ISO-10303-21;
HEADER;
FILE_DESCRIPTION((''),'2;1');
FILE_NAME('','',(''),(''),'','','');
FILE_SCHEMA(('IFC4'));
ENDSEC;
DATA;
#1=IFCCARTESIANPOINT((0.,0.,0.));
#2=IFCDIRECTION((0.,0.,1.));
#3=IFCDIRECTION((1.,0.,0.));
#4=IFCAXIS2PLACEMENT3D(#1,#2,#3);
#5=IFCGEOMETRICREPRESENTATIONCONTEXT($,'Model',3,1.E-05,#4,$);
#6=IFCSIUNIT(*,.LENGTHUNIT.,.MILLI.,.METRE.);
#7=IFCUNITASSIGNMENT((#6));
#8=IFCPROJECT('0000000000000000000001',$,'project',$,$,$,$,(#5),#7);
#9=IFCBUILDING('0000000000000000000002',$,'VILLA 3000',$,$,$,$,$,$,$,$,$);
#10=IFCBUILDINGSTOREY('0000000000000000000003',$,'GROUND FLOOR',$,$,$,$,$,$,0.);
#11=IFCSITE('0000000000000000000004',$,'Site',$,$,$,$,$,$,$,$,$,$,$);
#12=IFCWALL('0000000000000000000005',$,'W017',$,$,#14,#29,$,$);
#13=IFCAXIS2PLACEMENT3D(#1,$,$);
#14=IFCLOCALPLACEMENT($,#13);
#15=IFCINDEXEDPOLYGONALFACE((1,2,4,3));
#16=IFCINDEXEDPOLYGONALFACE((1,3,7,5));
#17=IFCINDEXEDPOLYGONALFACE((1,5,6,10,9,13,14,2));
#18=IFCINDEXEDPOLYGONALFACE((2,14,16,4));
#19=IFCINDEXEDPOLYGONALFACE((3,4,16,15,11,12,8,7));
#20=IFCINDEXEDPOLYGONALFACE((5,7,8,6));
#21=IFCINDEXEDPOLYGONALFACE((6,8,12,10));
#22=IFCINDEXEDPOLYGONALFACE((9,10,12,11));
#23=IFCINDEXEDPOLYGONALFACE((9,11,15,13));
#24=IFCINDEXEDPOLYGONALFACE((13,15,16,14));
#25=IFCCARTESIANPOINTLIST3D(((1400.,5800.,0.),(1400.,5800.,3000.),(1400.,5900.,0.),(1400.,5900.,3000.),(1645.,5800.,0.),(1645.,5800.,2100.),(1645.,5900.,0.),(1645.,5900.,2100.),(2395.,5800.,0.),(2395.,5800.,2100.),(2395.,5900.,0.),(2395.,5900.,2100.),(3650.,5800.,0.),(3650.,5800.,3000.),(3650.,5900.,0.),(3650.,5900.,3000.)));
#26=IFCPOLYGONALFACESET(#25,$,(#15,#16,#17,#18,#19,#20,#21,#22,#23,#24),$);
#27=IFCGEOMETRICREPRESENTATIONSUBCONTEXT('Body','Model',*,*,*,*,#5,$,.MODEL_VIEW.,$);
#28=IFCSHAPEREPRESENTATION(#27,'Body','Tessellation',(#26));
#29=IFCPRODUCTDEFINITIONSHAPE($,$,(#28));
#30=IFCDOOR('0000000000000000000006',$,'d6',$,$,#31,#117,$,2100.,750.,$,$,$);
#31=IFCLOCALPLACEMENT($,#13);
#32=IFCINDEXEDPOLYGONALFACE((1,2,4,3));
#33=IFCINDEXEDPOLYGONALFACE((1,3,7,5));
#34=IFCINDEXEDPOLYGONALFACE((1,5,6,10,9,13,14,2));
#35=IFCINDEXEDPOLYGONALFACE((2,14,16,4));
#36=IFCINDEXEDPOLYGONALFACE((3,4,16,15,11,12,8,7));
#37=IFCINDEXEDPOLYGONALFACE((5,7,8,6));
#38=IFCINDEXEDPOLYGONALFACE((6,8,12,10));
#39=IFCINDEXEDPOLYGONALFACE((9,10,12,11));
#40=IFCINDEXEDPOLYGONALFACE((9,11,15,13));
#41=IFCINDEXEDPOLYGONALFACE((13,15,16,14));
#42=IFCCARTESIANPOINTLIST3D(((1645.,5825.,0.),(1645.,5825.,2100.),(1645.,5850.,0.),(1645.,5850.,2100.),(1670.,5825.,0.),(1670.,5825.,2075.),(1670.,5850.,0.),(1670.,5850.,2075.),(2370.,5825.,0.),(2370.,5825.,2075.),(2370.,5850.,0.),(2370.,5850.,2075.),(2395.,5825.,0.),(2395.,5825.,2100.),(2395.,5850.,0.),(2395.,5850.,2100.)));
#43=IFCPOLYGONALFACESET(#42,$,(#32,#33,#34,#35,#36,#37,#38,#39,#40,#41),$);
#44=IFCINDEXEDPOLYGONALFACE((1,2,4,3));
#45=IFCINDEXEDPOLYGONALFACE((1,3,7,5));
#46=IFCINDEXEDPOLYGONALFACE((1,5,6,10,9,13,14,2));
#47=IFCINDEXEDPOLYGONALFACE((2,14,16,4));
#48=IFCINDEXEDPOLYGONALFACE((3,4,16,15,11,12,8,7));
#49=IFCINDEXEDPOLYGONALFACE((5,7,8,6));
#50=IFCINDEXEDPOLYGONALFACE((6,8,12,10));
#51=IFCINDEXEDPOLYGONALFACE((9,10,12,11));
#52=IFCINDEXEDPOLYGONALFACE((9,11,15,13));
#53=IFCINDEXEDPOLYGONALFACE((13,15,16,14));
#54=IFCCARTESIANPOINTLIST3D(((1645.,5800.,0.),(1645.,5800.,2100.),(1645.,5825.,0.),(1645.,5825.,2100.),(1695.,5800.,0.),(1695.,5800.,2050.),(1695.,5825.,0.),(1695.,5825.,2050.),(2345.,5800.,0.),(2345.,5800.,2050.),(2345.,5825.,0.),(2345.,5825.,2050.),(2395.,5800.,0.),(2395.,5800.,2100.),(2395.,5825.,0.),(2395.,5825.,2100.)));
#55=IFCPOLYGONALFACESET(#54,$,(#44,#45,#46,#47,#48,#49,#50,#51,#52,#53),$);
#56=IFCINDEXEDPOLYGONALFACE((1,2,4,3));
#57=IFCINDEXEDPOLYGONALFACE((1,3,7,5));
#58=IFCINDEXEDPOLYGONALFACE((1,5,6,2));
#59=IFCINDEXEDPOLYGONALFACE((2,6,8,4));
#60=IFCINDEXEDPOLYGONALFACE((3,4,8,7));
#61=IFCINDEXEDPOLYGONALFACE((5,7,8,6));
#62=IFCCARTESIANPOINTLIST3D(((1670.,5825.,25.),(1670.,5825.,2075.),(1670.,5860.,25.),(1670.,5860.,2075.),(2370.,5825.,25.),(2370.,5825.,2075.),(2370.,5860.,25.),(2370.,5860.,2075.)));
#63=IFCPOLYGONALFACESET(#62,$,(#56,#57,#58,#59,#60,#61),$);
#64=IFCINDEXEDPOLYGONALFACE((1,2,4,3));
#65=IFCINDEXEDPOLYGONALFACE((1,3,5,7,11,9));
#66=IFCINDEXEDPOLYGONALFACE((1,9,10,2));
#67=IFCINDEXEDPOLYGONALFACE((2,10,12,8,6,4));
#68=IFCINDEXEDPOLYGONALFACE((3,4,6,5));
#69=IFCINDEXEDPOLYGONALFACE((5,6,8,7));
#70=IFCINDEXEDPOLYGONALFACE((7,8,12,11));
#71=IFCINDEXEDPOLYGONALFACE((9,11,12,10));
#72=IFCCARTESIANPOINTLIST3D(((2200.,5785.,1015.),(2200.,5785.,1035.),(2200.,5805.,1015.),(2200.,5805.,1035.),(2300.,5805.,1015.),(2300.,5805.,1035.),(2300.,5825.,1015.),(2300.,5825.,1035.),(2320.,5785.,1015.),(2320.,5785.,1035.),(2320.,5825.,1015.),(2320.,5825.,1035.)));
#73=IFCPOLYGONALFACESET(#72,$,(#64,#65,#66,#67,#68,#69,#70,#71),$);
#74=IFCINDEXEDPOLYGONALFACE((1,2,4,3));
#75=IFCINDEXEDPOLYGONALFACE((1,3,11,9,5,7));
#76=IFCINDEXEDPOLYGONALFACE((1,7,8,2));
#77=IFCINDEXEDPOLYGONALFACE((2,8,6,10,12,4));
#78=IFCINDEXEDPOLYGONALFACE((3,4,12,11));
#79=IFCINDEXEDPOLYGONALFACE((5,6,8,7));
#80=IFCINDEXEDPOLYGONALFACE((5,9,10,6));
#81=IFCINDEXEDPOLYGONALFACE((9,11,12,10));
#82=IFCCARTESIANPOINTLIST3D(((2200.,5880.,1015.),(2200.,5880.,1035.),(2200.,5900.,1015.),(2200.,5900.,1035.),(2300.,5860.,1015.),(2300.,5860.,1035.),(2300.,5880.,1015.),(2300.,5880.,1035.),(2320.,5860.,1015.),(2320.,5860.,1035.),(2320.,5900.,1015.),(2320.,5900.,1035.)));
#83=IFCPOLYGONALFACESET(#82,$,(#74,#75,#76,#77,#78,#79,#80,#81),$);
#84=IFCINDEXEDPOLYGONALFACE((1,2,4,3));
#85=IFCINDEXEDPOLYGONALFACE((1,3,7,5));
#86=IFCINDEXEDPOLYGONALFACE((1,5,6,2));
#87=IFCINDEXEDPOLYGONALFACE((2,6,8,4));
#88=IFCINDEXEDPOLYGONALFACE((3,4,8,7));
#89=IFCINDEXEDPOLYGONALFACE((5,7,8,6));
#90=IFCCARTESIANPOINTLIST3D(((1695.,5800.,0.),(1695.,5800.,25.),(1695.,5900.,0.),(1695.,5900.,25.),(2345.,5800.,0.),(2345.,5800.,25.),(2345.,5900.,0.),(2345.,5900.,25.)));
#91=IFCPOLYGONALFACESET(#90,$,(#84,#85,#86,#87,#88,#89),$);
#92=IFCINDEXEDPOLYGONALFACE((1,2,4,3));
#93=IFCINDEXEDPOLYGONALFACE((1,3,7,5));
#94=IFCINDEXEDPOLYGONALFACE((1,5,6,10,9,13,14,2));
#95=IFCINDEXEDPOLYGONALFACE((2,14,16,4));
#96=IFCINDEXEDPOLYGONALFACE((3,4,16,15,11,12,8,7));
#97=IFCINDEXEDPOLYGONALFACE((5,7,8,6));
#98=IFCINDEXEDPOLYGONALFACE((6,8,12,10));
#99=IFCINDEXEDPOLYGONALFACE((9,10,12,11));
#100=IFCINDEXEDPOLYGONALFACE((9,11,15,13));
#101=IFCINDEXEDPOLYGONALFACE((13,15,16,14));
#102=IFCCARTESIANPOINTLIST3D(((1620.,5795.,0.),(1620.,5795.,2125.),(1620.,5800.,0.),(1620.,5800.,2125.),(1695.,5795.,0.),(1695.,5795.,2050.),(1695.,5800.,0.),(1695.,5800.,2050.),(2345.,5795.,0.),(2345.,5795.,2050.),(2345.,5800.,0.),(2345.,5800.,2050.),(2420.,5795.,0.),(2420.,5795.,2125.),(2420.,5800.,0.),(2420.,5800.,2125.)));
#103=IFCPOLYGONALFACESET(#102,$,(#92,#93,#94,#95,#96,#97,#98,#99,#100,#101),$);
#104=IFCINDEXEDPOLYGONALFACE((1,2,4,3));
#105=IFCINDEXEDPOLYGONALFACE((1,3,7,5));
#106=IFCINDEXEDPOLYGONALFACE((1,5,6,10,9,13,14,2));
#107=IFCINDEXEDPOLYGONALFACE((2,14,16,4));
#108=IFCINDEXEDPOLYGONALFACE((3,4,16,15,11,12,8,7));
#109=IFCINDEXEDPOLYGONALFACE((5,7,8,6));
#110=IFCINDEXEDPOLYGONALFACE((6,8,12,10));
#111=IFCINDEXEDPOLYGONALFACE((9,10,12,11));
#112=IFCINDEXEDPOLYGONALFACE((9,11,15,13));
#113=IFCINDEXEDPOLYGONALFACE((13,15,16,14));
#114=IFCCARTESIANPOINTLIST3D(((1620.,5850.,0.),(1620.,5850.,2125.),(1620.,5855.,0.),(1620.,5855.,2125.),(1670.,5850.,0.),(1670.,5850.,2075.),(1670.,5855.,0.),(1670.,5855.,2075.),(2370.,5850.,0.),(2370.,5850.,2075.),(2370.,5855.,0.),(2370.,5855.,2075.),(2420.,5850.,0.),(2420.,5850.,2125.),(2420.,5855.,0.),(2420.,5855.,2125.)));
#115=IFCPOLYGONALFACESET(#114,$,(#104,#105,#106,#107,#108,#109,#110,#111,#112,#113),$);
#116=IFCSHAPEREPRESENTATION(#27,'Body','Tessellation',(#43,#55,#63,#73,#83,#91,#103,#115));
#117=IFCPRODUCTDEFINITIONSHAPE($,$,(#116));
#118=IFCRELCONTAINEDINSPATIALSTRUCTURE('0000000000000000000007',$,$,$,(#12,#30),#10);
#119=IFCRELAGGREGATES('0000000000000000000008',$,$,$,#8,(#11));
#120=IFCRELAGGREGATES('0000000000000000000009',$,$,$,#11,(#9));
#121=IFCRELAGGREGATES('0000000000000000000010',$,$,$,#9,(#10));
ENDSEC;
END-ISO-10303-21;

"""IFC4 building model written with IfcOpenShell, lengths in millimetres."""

from ifc_helpers import new_model, si_unit, frame, origin_with_axes, place, context, subcontext, project, spatial, line, indexed_curve, outline, extrude, element, fill, save


model = new_model("IFC4")

# Units and contexts
model_context = context("Model", 3, precision=1e-05, world=origin_with_axes())
body_context = subcontext(model_context, "Body", "Model", "MODEL_VIEW")
ifc_project = project(units=[si_unit("LENGTHUNIT", "METRE", prefix="MILLI")], contexts=[model_context])

# Site, building, storey
site = spatial("IfcSite", under=ifc_project, Name="Site")
building = spatial("IfcBuilding", under=site, Name="VILLA 3000")
storey = spatial("IfcBuildingStorey", under=building, Name="GROUND FLOOR", Elevation=0.0)

# Wall, opening, door
wall_1_placement = place(None, frame((1400.0, 5850.0, 0.0), z_axis=(0.0, 0.0, 1.0), x_axis=(1.0, 0.0, 0.0)))
wall_1 = element("IfcWall", 1, at=wall_1_placement, inside=storey, Name="W017", context=body_context, shape_type="SweptSolid", body=[
    extrude(outline(indexed_curve([(0.0, 0.0), (0.0, 100.0), (2250.0, 100.0), (2250.0, 0.0), (0.0, 0.0)], self_intersect=False)), frame((0.0, -50.0, 0.0), z_axis=(0.0, 0.0, 1.0), x_axis=(1.0, 0.0, 0.0)), (0.0, 0.0, 1.0), 3000.0),
])
opening_1_placement = place(wall_1_placement, frame((245.0, 0.0, 0.0), z_axis=(0.0, 0.0, 1.0), x_axis=(1.0, 0.0, 0.0)))
opening_1 = element("IfcOpeningElement", 2, at=opening_1_placement, cuts=wall_1, context=body_context, shape_type="SweptSolid", body=[
    extrude(outline(indexed_curve([(0.0, 0.0), (0.0, 200.0), (750.0, 200.0), (750.0, 0.0), (0.0, 0.0)], self_intersect=False)), frame((0.0, -100.0, 0.0), z_axis=(0.0, 0.0, 1.0), x_axis=(1.0, 0.0, 0.0)), (0.0, 0.0, 1.0), 2100.0),
])
door_1_placement = place(None, frame((1645.0, 5800.0, 0.0), z_axis=(0.0, 0.0, 1.0), x_axis=(1.0, 0.0, 0.0)))
door_1 = element("IfcDoor", 3, at=door_1_placement, inside=storey, Name="d6", OverallHeight=2100.0, OverallWidth=750.0, context=body_context, shape_type="SweptSolid", body=[
    extrude(outline(indexed_curve([(0.0, 0.0), (0.0, 2100.0), (750.0, 2100.0), (750.0, 0.0), (725.0, 0.0), (725.0, 2075.0), (25.0, 2075.0), (25.0, 0.0)], segments=[line(1, 2, 3, 4, 5, 6, 7, 8, 1)])), frame((0.0, 25.0, 0.0), z_axis=(0.0, -1.0, 0.0), x_axis=(1.0, 0.0, 0.0)), (0.0, 0.0, -1.0), 25.0),
    extrude(outline(indexed_curve([(0.0, 0.0), (0.0, 2100.0), (750.0, 2100.0), (750.0, 0.0), (700.0, 0.0), (700.0, 2050.0), (50.0, 2050.0), (50.0, 0.0)], segments=[line(1, 2, 3, 4, 5, 6, 7, 8, 1)])), frame((0.0, 0.0, 0.0), z_axis=(0.0, -1.0, 0.0), x_axis=(1.0, 0.0, 0.0)), (0.0, 0.0, -1.0), 25.0),
    extrude(outline(indexed_curve([(0.0, 0.0), (700.0, 0.0), (700.0, 35.0), (0.0, 35.0)], segments=[line(1, 2, 3, 4, 1)])), frame((25.0, 25.0, 25.0), z_axis=(0.0, 0.0, 1.0), x_axis=(1.0, 0.0, 0.0)), (0.0, 0.0, 1.0), 2050.0),
    extrude(outline(indexed_curve([(0.0, 0.0), (0.0, -40.0), (-120.0, -40.0), (-120.0, -20.0), (-20.0, -20.0), (-20.0, 0.0)], segments=[line(1, 2, 3, 4, 5, 6, 1)])), frame((675.0, 25.0, 1015.0), z_axis=(0.0, 0.0, 1.0), x_axis=(1.0, 0.0, 0.0)), (0.0, 0.0, 1.0), 20.0),
    extrude(outline(indexed_curve([(0.0, 0.0), (0.0, 40.0), (-120.0, 40.0), (-120.0, 20.0), (-20.0, 20.0), (-20.0, 0.0)], segments=[line(1, 2, 3, 4, 5, 6, 1)])), frame((675.0, 60.0, 1015.0), z_axis=(0.0, 0.0, 1.0), x_axis=(1.0, 0.0, 0.0)), (0.0, 0.0, 1.0), 20.0),
    extrude(outline(indexed_curve([(0.0, 0.0), (650.0, 0.0), (650.0, 100.0), (0.0, 100.0)], segments=[line(1, 2, 3, 4, 1)])), frame((50.0, 0.0, 0.0), z_axis=(0.0, 0.0, 1.0), x_axis=(1.0, 0.0, 0.0)), (0.0, 0.0, 1.0), 25.0),
    extrude(outline(indexed_curve([(0.0, 0.0), (0.0, 2125.0), (800.0, 2125.0), (800.0, 0.0), (725.0, 0.0), (725.0, 2050.0), (75.0, 2050.0), (75.0, 0.0)], segments=[line(1, 2, 3, 4, 5, 6, 7, 8, 1)])), frame((-25.0, -5.0, 0.0), z_axis=(0.0, -1.0, 0.0), x_axis=(1.0, 0.0, 0.0)), (0.0, 0.0, -1.0), 5.0),
    extrude(outline(indexed_curve([(0.0, 0.0), (0.0, 2125.0), (800.0, 2125.0), (800.0, 0.0), (750.0, 0.0), (750.0, 2075.0), (50.0, 2075.0), (50.0, 0.0)], segments=[line(1, 2, 3, 4, 5, 6, 7, 8, 1)])), frame((-25.0, 50.0, 0.0), z_axis=(0.0, -1.0, 0.0), x_axis=(1.0, 0.0, 0.0)), (0.0, 0.0, -1.0), 5.0),
])
fill(opening_1, door_1)

save(model, "model.ifc")
